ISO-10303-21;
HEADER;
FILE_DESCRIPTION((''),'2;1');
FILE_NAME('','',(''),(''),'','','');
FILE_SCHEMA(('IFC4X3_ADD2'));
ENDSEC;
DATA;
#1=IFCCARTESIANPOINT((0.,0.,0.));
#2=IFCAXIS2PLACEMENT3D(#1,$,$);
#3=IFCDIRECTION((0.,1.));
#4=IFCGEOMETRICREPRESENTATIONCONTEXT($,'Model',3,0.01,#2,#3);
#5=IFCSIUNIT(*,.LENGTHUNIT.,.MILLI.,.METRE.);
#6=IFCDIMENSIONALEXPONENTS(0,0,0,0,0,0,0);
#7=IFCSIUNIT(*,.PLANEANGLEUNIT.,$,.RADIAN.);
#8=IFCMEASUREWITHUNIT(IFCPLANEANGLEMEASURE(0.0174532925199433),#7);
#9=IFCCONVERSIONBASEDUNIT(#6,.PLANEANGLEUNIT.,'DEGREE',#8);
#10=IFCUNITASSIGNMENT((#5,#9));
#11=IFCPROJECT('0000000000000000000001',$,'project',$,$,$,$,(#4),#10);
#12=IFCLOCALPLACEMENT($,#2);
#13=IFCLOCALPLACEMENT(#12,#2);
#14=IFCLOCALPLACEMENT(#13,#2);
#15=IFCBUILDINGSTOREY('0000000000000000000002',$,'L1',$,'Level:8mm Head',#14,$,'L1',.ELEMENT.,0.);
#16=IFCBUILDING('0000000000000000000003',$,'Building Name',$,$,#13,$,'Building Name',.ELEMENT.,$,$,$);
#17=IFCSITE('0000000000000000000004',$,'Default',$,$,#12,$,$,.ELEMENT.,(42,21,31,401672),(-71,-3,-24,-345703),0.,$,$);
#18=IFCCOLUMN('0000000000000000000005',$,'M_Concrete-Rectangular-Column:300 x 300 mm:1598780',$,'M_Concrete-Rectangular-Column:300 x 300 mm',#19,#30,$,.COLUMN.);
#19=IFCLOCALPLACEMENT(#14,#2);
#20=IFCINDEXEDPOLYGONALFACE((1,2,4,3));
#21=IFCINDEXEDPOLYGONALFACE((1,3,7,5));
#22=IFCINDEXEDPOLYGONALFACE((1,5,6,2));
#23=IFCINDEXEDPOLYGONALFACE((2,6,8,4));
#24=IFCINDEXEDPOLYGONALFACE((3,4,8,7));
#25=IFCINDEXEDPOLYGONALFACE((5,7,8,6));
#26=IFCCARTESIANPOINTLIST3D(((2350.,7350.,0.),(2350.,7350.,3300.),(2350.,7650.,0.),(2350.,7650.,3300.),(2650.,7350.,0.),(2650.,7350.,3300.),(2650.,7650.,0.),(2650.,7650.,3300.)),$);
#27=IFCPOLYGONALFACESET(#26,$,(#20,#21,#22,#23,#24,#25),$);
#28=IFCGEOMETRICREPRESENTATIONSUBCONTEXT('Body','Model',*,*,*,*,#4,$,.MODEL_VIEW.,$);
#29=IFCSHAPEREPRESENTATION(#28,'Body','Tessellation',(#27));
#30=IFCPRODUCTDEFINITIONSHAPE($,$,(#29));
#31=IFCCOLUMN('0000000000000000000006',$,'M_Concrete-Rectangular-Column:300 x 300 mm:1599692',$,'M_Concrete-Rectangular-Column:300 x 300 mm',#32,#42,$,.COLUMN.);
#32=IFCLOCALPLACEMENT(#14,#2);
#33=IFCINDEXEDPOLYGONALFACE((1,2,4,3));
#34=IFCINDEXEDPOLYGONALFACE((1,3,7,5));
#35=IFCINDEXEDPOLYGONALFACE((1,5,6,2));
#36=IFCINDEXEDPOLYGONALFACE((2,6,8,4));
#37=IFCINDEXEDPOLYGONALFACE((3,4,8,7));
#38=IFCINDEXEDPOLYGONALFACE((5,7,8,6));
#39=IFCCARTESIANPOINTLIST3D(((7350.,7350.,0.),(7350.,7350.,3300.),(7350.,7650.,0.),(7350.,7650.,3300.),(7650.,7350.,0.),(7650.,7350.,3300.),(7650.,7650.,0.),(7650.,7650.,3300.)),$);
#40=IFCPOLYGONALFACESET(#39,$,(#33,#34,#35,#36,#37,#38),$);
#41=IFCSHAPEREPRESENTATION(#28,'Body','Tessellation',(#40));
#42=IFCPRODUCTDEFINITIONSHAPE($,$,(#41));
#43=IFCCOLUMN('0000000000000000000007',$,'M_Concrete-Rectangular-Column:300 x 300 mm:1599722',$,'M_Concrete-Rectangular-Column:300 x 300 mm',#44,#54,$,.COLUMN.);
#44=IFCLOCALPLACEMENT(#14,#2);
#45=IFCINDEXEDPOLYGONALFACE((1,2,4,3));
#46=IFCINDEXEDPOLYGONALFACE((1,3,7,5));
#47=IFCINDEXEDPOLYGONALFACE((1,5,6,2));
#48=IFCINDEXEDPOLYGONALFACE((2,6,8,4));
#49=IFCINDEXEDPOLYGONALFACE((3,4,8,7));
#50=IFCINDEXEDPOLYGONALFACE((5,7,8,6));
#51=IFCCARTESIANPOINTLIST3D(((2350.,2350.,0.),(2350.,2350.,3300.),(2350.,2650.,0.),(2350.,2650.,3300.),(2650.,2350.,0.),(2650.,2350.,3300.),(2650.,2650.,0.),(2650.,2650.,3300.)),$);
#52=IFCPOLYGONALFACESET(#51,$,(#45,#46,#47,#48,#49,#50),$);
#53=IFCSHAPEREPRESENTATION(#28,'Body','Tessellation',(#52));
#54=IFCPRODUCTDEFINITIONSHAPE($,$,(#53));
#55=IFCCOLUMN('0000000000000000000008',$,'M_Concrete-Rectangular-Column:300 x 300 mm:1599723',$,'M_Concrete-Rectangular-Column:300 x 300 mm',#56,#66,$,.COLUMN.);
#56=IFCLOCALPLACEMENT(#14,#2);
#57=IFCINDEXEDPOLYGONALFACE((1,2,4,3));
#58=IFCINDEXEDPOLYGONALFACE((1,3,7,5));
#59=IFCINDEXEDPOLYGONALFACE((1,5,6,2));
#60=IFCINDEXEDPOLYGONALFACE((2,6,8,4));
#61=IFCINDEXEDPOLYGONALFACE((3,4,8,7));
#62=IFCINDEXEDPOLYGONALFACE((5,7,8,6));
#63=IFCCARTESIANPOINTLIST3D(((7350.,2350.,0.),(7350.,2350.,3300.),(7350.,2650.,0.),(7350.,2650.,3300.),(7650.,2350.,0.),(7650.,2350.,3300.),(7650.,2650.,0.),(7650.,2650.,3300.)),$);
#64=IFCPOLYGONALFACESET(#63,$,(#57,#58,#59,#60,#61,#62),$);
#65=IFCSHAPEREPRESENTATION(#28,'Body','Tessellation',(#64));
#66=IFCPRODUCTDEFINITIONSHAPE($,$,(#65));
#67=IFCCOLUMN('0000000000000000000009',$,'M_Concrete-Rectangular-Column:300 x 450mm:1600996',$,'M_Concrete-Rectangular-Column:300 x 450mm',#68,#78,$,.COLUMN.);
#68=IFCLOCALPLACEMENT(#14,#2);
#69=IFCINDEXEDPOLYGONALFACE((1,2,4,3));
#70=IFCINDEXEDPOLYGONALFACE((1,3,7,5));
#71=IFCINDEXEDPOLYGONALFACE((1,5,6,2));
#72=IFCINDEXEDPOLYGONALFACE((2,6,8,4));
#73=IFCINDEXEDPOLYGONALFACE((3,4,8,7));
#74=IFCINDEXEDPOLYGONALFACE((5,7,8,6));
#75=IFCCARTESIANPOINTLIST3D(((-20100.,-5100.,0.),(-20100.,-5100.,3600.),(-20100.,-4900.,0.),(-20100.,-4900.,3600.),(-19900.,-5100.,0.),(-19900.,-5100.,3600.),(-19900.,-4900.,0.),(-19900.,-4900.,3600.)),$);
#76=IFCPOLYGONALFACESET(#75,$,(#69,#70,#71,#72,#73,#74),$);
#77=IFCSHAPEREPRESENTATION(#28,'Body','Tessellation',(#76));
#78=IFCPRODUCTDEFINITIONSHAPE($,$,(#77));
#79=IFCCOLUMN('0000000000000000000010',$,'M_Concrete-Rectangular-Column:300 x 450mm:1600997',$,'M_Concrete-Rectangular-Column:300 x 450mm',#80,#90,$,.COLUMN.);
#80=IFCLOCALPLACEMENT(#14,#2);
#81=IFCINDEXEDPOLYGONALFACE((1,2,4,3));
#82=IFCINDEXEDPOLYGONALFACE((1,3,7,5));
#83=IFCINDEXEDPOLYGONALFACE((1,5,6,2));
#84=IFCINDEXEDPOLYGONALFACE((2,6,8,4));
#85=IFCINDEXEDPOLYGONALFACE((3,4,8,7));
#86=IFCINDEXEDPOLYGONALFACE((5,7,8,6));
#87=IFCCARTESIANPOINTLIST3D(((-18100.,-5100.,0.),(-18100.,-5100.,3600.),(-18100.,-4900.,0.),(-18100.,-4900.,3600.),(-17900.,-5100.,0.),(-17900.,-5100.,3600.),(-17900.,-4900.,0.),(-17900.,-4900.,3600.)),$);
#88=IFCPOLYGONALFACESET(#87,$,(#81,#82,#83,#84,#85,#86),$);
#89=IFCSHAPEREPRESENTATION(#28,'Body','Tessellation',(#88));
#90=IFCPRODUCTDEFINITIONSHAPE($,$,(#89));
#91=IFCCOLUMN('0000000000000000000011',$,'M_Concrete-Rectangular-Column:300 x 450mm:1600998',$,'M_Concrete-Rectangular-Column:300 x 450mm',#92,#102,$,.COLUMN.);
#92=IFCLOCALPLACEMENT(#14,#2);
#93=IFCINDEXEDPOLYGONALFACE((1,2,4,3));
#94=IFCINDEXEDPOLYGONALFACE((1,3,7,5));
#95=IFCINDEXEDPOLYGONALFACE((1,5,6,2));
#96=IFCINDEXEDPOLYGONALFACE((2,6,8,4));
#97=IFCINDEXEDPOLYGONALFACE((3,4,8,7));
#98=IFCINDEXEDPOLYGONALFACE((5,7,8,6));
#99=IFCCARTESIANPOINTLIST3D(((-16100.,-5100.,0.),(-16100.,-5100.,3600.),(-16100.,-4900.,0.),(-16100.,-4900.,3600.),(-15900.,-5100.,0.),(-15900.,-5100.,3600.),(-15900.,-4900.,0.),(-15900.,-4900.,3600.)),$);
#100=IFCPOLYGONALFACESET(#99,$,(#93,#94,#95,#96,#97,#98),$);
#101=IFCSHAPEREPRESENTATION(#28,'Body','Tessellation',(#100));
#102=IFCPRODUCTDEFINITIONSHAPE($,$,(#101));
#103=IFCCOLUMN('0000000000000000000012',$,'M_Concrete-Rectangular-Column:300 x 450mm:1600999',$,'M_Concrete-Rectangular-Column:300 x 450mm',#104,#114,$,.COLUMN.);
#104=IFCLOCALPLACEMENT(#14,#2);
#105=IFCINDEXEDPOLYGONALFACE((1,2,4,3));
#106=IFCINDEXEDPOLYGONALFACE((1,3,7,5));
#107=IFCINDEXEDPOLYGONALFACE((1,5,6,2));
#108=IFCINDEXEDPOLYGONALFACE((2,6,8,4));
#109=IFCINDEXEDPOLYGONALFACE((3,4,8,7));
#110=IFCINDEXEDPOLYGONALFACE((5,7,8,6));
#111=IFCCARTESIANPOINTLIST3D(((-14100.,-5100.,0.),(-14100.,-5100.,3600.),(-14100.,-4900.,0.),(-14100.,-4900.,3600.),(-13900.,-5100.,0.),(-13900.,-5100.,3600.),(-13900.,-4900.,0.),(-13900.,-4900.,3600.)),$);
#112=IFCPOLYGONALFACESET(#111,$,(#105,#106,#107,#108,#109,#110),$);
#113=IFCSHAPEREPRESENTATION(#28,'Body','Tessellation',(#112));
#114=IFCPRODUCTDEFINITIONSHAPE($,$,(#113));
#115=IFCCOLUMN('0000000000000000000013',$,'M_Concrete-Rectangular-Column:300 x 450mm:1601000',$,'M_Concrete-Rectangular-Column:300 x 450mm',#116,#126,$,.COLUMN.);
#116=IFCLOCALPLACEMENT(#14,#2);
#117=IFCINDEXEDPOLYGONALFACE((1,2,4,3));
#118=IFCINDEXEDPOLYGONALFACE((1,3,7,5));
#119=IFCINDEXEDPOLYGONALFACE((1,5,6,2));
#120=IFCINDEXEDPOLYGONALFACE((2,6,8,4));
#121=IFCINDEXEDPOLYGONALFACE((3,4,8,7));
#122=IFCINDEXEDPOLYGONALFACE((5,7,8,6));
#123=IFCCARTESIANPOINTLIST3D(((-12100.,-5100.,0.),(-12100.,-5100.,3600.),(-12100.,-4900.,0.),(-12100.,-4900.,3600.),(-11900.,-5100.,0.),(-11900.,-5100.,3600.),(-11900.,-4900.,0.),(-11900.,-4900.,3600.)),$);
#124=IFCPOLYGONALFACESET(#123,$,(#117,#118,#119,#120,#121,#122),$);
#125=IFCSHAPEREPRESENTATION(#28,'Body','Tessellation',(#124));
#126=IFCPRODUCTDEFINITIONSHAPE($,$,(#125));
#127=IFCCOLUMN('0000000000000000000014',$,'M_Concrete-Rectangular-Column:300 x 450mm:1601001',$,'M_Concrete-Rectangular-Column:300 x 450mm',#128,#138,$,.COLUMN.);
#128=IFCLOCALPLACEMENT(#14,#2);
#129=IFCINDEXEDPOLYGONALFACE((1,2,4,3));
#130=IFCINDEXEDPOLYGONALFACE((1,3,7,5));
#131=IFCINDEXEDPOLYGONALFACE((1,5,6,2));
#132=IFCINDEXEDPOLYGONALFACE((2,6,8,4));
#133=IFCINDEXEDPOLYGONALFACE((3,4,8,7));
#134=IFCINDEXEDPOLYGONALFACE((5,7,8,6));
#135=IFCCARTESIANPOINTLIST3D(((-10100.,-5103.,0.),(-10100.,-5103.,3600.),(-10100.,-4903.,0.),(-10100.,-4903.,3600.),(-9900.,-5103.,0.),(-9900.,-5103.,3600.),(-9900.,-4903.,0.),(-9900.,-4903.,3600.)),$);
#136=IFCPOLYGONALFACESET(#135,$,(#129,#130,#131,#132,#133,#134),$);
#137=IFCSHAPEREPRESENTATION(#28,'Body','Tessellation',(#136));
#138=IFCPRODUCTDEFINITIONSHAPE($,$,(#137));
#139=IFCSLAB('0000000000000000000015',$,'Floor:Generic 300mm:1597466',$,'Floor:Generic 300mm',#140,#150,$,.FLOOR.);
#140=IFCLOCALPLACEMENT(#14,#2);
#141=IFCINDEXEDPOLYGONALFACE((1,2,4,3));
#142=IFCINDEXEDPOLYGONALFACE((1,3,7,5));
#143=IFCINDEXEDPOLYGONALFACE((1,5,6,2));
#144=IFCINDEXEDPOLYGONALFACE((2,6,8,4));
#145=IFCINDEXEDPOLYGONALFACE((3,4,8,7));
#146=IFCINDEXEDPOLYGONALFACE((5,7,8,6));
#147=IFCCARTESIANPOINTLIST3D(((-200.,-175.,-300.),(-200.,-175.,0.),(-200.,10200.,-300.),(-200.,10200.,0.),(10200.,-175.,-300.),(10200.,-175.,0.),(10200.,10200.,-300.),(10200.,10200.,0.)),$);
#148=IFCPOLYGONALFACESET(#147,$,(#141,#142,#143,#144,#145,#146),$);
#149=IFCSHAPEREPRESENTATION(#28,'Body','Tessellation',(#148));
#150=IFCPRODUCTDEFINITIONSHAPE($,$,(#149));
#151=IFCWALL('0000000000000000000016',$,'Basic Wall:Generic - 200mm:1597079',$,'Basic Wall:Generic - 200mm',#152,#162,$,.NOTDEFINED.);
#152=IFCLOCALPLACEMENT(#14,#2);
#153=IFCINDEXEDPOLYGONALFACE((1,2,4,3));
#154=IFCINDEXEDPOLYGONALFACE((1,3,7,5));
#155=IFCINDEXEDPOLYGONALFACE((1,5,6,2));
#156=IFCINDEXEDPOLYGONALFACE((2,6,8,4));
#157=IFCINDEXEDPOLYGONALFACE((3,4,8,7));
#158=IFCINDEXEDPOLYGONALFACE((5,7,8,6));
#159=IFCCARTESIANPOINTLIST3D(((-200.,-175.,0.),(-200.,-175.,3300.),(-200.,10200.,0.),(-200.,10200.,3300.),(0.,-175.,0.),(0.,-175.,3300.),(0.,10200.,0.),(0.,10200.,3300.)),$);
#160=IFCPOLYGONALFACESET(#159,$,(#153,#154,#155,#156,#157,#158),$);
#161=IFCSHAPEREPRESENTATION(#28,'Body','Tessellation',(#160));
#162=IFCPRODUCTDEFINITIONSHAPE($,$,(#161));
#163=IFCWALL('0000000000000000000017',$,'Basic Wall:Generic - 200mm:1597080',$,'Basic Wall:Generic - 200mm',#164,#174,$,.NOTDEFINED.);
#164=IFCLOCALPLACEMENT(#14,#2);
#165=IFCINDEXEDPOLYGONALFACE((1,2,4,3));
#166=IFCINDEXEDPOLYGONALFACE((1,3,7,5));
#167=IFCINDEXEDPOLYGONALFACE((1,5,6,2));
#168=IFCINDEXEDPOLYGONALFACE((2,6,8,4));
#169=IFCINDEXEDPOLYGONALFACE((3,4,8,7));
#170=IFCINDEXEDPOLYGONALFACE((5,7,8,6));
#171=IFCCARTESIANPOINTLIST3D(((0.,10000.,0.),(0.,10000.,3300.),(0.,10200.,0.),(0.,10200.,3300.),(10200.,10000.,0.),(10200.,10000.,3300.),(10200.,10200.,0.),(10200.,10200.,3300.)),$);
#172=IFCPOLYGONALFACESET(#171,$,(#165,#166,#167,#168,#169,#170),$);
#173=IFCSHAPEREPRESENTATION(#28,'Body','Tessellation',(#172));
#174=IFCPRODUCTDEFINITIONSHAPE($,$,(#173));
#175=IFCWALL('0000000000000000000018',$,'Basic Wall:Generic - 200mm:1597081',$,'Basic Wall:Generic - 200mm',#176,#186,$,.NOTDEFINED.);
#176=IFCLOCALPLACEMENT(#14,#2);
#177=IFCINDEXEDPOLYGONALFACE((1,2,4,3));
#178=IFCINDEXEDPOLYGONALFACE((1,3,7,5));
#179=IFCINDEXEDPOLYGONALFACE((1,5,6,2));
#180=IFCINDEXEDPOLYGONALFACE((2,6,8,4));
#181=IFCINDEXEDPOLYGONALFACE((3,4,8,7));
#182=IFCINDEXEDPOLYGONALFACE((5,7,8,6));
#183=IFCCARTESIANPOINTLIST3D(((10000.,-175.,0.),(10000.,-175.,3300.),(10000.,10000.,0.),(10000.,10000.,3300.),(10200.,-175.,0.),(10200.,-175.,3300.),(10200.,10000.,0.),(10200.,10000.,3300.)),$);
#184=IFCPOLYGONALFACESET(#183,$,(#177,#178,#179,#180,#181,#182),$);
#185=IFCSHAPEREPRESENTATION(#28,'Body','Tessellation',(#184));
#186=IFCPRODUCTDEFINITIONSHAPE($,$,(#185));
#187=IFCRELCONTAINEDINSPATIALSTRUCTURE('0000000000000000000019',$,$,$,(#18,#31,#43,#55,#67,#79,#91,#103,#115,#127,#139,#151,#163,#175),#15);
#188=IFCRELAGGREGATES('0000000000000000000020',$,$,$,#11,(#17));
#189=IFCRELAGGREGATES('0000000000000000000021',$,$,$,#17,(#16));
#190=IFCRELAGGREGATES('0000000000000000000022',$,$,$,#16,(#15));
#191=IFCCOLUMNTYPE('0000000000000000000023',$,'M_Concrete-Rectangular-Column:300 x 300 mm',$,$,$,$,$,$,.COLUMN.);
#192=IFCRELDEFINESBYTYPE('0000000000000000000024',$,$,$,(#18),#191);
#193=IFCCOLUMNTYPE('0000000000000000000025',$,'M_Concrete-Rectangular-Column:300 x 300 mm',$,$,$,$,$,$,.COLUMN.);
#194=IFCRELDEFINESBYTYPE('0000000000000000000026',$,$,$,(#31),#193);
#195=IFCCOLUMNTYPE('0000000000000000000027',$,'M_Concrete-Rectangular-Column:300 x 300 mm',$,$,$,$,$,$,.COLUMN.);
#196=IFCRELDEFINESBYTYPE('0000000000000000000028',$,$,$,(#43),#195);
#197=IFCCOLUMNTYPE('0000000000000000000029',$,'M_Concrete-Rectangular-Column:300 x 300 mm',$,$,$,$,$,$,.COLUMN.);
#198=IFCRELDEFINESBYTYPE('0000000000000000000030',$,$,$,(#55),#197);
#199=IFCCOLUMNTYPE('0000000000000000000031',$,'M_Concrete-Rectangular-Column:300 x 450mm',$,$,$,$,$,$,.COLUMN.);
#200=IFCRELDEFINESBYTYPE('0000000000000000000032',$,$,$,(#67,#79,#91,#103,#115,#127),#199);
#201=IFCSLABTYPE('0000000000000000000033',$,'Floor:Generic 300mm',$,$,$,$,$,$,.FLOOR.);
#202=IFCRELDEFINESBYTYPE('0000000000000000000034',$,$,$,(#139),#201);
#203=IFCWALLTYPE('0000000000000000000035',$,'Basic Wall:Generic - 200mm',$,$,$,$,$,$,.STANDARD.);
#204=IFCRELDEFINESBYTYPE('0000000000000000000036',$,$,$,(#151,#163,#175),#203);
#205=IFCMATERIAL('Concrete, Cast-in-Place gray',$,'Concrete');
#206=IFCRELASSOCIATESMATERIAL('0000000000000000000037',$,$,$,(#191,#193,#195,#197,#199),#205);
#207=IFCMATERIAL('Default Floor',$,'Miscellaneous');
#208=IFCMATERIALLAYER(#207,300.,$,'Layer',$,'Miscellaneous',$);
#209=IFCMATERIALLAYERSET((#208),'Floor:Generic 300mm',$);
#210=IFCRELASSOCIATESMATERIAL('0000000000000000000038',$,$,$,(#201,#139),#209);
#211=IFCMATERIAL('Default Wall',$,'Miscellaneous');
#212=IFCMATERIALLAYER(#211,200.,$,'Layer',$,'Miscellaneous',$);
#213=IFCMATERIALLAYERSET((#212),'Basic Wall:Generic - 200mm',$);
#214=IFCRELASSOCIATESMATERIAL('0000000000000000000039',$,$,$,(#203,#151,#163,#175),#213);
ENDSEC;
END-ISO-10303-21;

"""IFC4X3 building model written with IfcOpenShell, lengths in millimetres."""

from ifc_helpers import new_model, entity, si_unit, converted_unit, direction, frame, frame_2d, origin, origin_2d_with_axis, place, context, subcontext, project, spatial, rectangle, extrude, source, transform, mapped, material, layer, layer_set, layer_usage, material_profile, profile_set, type_object, type_shapes, element, save


model = new_model("IFC4X3")

# Units and contexts
model_context = context("Model", 3, precision=0.01, world=origin(), true_north=direction((0.0, 1.0)))
body_context = subcontext(model_context, "Body", "Model", "MODEL_VIEW")
ifc_project = project(units=[si_unit("LENGTHUNIT", "METRE", prefix="MILLI"), converted_unit("PLANEANGLEUNIT", "DEGREE", entity("IfcPlaneAngleMeasure", 0.0174532925199433), si_unit("PLANEANGLEUNIT", "RADIAN"), dimensions=[0, 0, 0, 0, 0, 0, 0])], contexts=[model_context])

# Site, building, storey
site_placement = place(None, origin())
site = spatial("IfcSite", under=ifc_project, at=site_placement, Name="Default", CompositionType="ELEMENT", RefLatitude=(42, 21, 31, 401672), RefLongitude=(-71, -3, -24, -345703), RefElevation=0.0)
building_placement = place(site_placement, origin())
building = spatial("IfcBuilding", under=site, at=building_placement, Name="Building Name", LongName="Building Name", CompositionType="ELEMENT")
storey_placement = place(building_placement, origin())
storey = spatial("IfcBuildingStorey", under=building, at=storey_placement, Name="L1", ObjectType="Level:8mm Head", LongName="L1", CompositionType="ELEMENT", Elevation=0.0)

# Columns
ifc_material_1 = material(Name="Concrete, Cast-in-Place gray", Category="Concrete")
ifc_material_profile_1 = material_profile(ifc_material_1, rectangle(XDim=300.0, YDim=300.0, at=origin_2d_with_axis()), Name="300 x 300 mm")
ifc_profile_set_1 = profile_set([ifc_material_profile_1], Name="300 x 300 mm")
column_type_1 = type_object("IfcColumnType", Name="M_Concrete-Rectangular-Column:300 x 300 mm", PredefinedType="COLUMN", material=ifc_profile_set_1)
shared_shape_1 = source(origin(), body_context, "Body", "SweptSolid", [
    extrude(rectangle(XDim=300.0, YDim=300.0, at=origin_2d_with_axis()), frame((2500.0, 7500.0, 0.0)), (0.0, 0.0, 1.0), 3300.0),
])
type_shapes(column_type_1, [shared_shape_1])
column_1_placement = place(storey_placement, origin())
element("IfcColumn", 1, at=column_1_placement, inside=storey, type_object=column_type_1, Name="M_Concrete-Rectangular-Column:300 x 300 mm:1598780", ObjectType="M_Concrete-Rectangular-Column:300 x 300 mm", PredefinedType="COLUMN", context=body_context, shape_type="MappedRepresentation", body=[
    mapped(shared_shape_1, transform((0.0, 0.0, 0.0), scale=1.0)),
])
column_type_2 = type_object("IfcColumnType", Name="M_Concrete-Rectangular-Column:300 x 300 mm", PredefinedType="COLUMN", material=ifc_profile_set_1)
shared_shape_2 = source(origin(), body_context, "Body", "SweptSolid", [
    extrude(rectangle(XDim=300.0, YDim=300.0, at=origin_2d_with_axis()), frame((7500.0, 7500.0, 0.0)), (0.0, 0.0, 1.0), 3300.0),
])
type_shapes(column_type_2, [shared_shape_2])
column_2_placement = place(storey_placement, origin())
element("IfcColumn", 2, at=column_2_placement, inside=storey, type_object=column_type_2, Name="M_Concrete-Rectangular-Column:300 x 300 mm:1599692", ObjectType="M_Concrete-Rectangular-Column:300 x 300 mm", PredefinedType="COLUMN", context=body_context, shape_type="MappedRepresentation", body=[
    mapped(shared_shape_2, transform((0.0, 0.0, 0.0), scale=1.0)),
])
column_type_3 = type_object("IfcColumnType", Name="M_Concrete-Rectangular-Column:300 x 300 mm", PredefinedType="COLUMN", material=ifc_profile_set_1)
shared_shape_3 = source(origin(), body_context, "Body", "SweptSolid", [
    extrude(rectangle(XDim=300.0, YDim=300.0, at=origin_2d_with_axis()), frame((2500.0, 2500.0, 0.0)), (0.0, 0.0, 1.0), 3300.0),
])
type_shapes(column_type_3, [shared_shape_3])
column_3_placement = place(storey_placement, origin())
element("IfcColumn", 3, at=column_3_placement, inside=storey, type_object=column_type_3, Name="M_Concrete-Rectangular-Column:300 x 300 mm:1599722", ObjectType="M_Concrete-Rectangular-Column:300 x 300 mm", PredefinedType="COLUMN", context=body_context, shape_type="MappedRepresentation", body=[
    mapped(shared_shape_3, transform((0.0, 0.0, 0.0), scale=1.0)),
])
column_type_4 = type_object("IfcColumnType", Name="M_Concrete-Rectangular-Column:300 x 300 mm", PredefinedType="COLUMN", material=ifc_profile_set_1)
shared_shape_4 = source(origin(), body_context, "Body", "SweptSolid", [
    extrude(rectangle(XDim=300.0, YDim=300.0, at=origin_2d_with_axis()), frame((7500.0, 2500.0, 0.0)), (0.0, 0.0, 1.0), 3300.0),
])
type_shapes(column_type_4, [shared_shape_4])
column_4_placement = place(storey_placement, origin())
element("IfcColumn", 4, at=column_4_placement, inside=storey, type_object=column_type_4, Name="M_Concrete-Rectangular-Column:300 x 300 mm:1599723", ObjectType="M_Concrete-Rectangular-Column:300 x 300 mm", PredefinedType="COLUMN", context=body_context, shape_type="MappedRepresentation", body=[
    mapped(shared_shape_4, transform((0.0, 0.0, 0.0), scale=1.0)),
])
ifc_material_profile_2 = material_profile(ifc_material_1, rectangle(XDim=200.0, YDim=200.0, at=origin_2d_with_axis()), Name="300 x 450mm")
ifc_profile_set_2 = profile_set([ifc_material_profile_2], Name="300 x 450mm")
column_type_5 = type_object("IfcColumnType", Name="M_Concrete-Rectangular-Column:300 x 450mm", PredefinedType="COLUMN", material=ifc_profile_set_2)
shared_shape_5 = source(origin(), body_context, "Body", "SweptSolid", [
    extrude(rectangle(XDim=200.0, YDim=200.0, at=origin_2d_with_axis()), frame((0.0, 0.0, 0.0), z_axis=(0.0, 0.0, 1.0), x_axis=(-1.0, 0.0, 0.0)), (0.0, 0.0, 1.0), 3600.0),
])
type_shapes(column_type_5, [shared_shape_5])
for number, where, z_axis, x_axis, name in (
    (5, (-20000.0, -5000.0, 0.0), (0.0, 0.0, 1.0), (0.0, -1.0, 0.0), "M_Concrete-Rectangular-Column:300 x 450mm:1600996"),
    (6, (-18000.0, -5000.0, 0.0), (0.0, 0.0, 1.0), (0.0, -1.0, 0.0), "M_Concrete-Rectangular-Column:300 x 450mm:1600997"),
    (7, (-16000.0, -5000.0, 0.0), (0.0, 0.0, 1.0), (0.0, -1.0, 0.0), "M_Concrete-Rectangular-Column:300 x 450mm:1600998"),
    (8, (-14000.0, -5000.0, 0.0), (0.0, 0.0, 1.0), (0.0, -1.0, 0.0), "M_Concrete-Rectangular-Column:300 x 450mm:1600999"),
    (9, (-12000.0, -5000.0, 0.0), (0.0, 0.0, 1.0), (0.0, -1.0, 0.0), "M_Concrete-Rectangular-Column:300 x 450mm:1601000"),
    (10, (-10000.0, -5003.0, 0.0), (0.0, 0.0, 1.0), (0.0, -1.0, 0.0), "M_Concrete-Rectangular-Column:300 x 450mm:1601001"),
):
    element("IfcColumn", number, at=place(storey_placement, frame(where, z_axis=z_axis, x_axis=x_axis)), inside=storey, type_object=column_type_5, Name=name, ObjectType="M_Concrete-Rectangular-Column:300 x 450mm", PredefinedType="COLUMN", context=body_context, shape_type="MappedRepresentation", body=[
        mapped(shared_shape_5, transform((0.0, 0.0, 0.0), scale=1.0)),
    ])

# Slab
ifc_material_2 = material(Name="Default Floor", Category="Miscellaneous")
ifc_layer_1 = layer(ifc_material_2, 300.0, Name="Layer", Category="Miscellaneous")
ifc_layer_set_1 = layer_set([ifc_layer_1], Name="Floor:Generic 300mm")
ifc_layer_usage = layer_usage(ifc_layer_set_1, "AXIS3", "POSITIVE", 0.0)
slab_type = type_object("IfcSlabType", Name="Floor:Generic 300mm", PredefinedType="FLOOR", material=ifc_layer_set_1)
slab_placement = place(storey_placement, origin())
element("IfcSlab", 11, at=slab_placement, inside=storey, type_object=slab_type, material=ifc_layer_usage, Name="Floor:Generic 300mm:1597466", ObjectType="Floor:Generic 300mm", PredefinedType="FLOOR", context=body_context, shape_type="SweptSolid", body=[
    extrude(rectangle(XDim=10375.0, YDim=10400.0, at=origin_2d_with_axis()), frame((5000.0, 5012.5, 0.0), z_axis=(0.0, 0.0, -1.0), x_axis=(0.0, 1.0, 0.0)), (0.0, 0.0, 1.0), 300.0),
])

# Walls
ifc_material_3 = material(Name="Default Wall", Category="Miscellaneous")
ifc_layer_2 = layer(ifc_material_3, 200.0, Name="Layer", Category="Miscellaneous")
ifc_layer_set_2 = layer_set([ifc_layer_2], Name="Basic Wall:Generic - 200mm")
wall_type_1 = type_object("IfcWallType", Name="Basic Wall:Generic - 200mm", PredefinedType="STANDARD", material=ifc_layer_set_2)
wall_1_placement = place(storey_placement, frame((-100.0, 10200.0, 0.0), z_axis=(0.0, 0.0, 1.0), x_axis=(0.0, -1.0, 0.0)))
element("IfcWall", 12, at=wall_1_placement, inside=storey, type_object=wall_type_1, material=ifc_layer_set_2, Name="Basic Wall:Generic - 200mm:1597079", ObjectType="Basic Wall:Generic - 200mm", PredefinedType="NOTDEFINED", context=body_context, shape_type="SweptSolid", body=[
    extrude(rectangle(XDim=10375.0, YDim=200.0, at=frame_2d((5187.5, 0.0), x_axis=(-1.0, 0.0))), origin(), (0.0, 0.0, 1.0), 3300.0),
])
wall_2_placement = place(storey_placement, frame((10200.0, 10100.0, 0.0), z_axis=(0.0, 0.0, 1.0), x_axis=(-1.0, 0.0, 0.0)))
element("IfcWall", 13, at=wall_2_placement, inside=storey, type_object=wall_type_1, material=ifc_layer_set_2, Name="Basic Wall:Generic - 200mm:1597080", ObjectType="Basic Wall:Generic - 200mm", PredefinedType="NOTDEFINED", context=body_context, shape_type="SweptSolid", body=[
    extrude(rectangle(XDim=10200.0, YDim=200.0, at=frame_2d((5100.0, 0.0), x_axis=(-1.0, 0.0))), origin(), (0.0, 0.0, 1.0), 3300.0),
])
wall_3_placement = place(storey_placement, frame((10100.0, -175.0, 0.0), z_axis=(0.0, 0.0, 1.0), x_axis=(0.0, 1.0, 0.0)))
element("IfcWall", 14, at=wall_3_placement, inside=storey, type_object=wall_type_1, material=ifc_layer_set_2, Name="Basic Wall:Generic - 200mm:1597081", ObjectType="Basic Wall:Generic - 200mm", PredefinedType="NOTDEFINED", context=body_context, shape_type="SweptSolid", body=[
    extrude(rectangle(XDim=10175.0, YDim=200.0, at=frame_2d((5087.5, 0.0), x_axis=(-1.0, 0.0))), origin(), (0.0, 0.0, 1.0), 3300.0),
])

save(model, "model.ifc")
